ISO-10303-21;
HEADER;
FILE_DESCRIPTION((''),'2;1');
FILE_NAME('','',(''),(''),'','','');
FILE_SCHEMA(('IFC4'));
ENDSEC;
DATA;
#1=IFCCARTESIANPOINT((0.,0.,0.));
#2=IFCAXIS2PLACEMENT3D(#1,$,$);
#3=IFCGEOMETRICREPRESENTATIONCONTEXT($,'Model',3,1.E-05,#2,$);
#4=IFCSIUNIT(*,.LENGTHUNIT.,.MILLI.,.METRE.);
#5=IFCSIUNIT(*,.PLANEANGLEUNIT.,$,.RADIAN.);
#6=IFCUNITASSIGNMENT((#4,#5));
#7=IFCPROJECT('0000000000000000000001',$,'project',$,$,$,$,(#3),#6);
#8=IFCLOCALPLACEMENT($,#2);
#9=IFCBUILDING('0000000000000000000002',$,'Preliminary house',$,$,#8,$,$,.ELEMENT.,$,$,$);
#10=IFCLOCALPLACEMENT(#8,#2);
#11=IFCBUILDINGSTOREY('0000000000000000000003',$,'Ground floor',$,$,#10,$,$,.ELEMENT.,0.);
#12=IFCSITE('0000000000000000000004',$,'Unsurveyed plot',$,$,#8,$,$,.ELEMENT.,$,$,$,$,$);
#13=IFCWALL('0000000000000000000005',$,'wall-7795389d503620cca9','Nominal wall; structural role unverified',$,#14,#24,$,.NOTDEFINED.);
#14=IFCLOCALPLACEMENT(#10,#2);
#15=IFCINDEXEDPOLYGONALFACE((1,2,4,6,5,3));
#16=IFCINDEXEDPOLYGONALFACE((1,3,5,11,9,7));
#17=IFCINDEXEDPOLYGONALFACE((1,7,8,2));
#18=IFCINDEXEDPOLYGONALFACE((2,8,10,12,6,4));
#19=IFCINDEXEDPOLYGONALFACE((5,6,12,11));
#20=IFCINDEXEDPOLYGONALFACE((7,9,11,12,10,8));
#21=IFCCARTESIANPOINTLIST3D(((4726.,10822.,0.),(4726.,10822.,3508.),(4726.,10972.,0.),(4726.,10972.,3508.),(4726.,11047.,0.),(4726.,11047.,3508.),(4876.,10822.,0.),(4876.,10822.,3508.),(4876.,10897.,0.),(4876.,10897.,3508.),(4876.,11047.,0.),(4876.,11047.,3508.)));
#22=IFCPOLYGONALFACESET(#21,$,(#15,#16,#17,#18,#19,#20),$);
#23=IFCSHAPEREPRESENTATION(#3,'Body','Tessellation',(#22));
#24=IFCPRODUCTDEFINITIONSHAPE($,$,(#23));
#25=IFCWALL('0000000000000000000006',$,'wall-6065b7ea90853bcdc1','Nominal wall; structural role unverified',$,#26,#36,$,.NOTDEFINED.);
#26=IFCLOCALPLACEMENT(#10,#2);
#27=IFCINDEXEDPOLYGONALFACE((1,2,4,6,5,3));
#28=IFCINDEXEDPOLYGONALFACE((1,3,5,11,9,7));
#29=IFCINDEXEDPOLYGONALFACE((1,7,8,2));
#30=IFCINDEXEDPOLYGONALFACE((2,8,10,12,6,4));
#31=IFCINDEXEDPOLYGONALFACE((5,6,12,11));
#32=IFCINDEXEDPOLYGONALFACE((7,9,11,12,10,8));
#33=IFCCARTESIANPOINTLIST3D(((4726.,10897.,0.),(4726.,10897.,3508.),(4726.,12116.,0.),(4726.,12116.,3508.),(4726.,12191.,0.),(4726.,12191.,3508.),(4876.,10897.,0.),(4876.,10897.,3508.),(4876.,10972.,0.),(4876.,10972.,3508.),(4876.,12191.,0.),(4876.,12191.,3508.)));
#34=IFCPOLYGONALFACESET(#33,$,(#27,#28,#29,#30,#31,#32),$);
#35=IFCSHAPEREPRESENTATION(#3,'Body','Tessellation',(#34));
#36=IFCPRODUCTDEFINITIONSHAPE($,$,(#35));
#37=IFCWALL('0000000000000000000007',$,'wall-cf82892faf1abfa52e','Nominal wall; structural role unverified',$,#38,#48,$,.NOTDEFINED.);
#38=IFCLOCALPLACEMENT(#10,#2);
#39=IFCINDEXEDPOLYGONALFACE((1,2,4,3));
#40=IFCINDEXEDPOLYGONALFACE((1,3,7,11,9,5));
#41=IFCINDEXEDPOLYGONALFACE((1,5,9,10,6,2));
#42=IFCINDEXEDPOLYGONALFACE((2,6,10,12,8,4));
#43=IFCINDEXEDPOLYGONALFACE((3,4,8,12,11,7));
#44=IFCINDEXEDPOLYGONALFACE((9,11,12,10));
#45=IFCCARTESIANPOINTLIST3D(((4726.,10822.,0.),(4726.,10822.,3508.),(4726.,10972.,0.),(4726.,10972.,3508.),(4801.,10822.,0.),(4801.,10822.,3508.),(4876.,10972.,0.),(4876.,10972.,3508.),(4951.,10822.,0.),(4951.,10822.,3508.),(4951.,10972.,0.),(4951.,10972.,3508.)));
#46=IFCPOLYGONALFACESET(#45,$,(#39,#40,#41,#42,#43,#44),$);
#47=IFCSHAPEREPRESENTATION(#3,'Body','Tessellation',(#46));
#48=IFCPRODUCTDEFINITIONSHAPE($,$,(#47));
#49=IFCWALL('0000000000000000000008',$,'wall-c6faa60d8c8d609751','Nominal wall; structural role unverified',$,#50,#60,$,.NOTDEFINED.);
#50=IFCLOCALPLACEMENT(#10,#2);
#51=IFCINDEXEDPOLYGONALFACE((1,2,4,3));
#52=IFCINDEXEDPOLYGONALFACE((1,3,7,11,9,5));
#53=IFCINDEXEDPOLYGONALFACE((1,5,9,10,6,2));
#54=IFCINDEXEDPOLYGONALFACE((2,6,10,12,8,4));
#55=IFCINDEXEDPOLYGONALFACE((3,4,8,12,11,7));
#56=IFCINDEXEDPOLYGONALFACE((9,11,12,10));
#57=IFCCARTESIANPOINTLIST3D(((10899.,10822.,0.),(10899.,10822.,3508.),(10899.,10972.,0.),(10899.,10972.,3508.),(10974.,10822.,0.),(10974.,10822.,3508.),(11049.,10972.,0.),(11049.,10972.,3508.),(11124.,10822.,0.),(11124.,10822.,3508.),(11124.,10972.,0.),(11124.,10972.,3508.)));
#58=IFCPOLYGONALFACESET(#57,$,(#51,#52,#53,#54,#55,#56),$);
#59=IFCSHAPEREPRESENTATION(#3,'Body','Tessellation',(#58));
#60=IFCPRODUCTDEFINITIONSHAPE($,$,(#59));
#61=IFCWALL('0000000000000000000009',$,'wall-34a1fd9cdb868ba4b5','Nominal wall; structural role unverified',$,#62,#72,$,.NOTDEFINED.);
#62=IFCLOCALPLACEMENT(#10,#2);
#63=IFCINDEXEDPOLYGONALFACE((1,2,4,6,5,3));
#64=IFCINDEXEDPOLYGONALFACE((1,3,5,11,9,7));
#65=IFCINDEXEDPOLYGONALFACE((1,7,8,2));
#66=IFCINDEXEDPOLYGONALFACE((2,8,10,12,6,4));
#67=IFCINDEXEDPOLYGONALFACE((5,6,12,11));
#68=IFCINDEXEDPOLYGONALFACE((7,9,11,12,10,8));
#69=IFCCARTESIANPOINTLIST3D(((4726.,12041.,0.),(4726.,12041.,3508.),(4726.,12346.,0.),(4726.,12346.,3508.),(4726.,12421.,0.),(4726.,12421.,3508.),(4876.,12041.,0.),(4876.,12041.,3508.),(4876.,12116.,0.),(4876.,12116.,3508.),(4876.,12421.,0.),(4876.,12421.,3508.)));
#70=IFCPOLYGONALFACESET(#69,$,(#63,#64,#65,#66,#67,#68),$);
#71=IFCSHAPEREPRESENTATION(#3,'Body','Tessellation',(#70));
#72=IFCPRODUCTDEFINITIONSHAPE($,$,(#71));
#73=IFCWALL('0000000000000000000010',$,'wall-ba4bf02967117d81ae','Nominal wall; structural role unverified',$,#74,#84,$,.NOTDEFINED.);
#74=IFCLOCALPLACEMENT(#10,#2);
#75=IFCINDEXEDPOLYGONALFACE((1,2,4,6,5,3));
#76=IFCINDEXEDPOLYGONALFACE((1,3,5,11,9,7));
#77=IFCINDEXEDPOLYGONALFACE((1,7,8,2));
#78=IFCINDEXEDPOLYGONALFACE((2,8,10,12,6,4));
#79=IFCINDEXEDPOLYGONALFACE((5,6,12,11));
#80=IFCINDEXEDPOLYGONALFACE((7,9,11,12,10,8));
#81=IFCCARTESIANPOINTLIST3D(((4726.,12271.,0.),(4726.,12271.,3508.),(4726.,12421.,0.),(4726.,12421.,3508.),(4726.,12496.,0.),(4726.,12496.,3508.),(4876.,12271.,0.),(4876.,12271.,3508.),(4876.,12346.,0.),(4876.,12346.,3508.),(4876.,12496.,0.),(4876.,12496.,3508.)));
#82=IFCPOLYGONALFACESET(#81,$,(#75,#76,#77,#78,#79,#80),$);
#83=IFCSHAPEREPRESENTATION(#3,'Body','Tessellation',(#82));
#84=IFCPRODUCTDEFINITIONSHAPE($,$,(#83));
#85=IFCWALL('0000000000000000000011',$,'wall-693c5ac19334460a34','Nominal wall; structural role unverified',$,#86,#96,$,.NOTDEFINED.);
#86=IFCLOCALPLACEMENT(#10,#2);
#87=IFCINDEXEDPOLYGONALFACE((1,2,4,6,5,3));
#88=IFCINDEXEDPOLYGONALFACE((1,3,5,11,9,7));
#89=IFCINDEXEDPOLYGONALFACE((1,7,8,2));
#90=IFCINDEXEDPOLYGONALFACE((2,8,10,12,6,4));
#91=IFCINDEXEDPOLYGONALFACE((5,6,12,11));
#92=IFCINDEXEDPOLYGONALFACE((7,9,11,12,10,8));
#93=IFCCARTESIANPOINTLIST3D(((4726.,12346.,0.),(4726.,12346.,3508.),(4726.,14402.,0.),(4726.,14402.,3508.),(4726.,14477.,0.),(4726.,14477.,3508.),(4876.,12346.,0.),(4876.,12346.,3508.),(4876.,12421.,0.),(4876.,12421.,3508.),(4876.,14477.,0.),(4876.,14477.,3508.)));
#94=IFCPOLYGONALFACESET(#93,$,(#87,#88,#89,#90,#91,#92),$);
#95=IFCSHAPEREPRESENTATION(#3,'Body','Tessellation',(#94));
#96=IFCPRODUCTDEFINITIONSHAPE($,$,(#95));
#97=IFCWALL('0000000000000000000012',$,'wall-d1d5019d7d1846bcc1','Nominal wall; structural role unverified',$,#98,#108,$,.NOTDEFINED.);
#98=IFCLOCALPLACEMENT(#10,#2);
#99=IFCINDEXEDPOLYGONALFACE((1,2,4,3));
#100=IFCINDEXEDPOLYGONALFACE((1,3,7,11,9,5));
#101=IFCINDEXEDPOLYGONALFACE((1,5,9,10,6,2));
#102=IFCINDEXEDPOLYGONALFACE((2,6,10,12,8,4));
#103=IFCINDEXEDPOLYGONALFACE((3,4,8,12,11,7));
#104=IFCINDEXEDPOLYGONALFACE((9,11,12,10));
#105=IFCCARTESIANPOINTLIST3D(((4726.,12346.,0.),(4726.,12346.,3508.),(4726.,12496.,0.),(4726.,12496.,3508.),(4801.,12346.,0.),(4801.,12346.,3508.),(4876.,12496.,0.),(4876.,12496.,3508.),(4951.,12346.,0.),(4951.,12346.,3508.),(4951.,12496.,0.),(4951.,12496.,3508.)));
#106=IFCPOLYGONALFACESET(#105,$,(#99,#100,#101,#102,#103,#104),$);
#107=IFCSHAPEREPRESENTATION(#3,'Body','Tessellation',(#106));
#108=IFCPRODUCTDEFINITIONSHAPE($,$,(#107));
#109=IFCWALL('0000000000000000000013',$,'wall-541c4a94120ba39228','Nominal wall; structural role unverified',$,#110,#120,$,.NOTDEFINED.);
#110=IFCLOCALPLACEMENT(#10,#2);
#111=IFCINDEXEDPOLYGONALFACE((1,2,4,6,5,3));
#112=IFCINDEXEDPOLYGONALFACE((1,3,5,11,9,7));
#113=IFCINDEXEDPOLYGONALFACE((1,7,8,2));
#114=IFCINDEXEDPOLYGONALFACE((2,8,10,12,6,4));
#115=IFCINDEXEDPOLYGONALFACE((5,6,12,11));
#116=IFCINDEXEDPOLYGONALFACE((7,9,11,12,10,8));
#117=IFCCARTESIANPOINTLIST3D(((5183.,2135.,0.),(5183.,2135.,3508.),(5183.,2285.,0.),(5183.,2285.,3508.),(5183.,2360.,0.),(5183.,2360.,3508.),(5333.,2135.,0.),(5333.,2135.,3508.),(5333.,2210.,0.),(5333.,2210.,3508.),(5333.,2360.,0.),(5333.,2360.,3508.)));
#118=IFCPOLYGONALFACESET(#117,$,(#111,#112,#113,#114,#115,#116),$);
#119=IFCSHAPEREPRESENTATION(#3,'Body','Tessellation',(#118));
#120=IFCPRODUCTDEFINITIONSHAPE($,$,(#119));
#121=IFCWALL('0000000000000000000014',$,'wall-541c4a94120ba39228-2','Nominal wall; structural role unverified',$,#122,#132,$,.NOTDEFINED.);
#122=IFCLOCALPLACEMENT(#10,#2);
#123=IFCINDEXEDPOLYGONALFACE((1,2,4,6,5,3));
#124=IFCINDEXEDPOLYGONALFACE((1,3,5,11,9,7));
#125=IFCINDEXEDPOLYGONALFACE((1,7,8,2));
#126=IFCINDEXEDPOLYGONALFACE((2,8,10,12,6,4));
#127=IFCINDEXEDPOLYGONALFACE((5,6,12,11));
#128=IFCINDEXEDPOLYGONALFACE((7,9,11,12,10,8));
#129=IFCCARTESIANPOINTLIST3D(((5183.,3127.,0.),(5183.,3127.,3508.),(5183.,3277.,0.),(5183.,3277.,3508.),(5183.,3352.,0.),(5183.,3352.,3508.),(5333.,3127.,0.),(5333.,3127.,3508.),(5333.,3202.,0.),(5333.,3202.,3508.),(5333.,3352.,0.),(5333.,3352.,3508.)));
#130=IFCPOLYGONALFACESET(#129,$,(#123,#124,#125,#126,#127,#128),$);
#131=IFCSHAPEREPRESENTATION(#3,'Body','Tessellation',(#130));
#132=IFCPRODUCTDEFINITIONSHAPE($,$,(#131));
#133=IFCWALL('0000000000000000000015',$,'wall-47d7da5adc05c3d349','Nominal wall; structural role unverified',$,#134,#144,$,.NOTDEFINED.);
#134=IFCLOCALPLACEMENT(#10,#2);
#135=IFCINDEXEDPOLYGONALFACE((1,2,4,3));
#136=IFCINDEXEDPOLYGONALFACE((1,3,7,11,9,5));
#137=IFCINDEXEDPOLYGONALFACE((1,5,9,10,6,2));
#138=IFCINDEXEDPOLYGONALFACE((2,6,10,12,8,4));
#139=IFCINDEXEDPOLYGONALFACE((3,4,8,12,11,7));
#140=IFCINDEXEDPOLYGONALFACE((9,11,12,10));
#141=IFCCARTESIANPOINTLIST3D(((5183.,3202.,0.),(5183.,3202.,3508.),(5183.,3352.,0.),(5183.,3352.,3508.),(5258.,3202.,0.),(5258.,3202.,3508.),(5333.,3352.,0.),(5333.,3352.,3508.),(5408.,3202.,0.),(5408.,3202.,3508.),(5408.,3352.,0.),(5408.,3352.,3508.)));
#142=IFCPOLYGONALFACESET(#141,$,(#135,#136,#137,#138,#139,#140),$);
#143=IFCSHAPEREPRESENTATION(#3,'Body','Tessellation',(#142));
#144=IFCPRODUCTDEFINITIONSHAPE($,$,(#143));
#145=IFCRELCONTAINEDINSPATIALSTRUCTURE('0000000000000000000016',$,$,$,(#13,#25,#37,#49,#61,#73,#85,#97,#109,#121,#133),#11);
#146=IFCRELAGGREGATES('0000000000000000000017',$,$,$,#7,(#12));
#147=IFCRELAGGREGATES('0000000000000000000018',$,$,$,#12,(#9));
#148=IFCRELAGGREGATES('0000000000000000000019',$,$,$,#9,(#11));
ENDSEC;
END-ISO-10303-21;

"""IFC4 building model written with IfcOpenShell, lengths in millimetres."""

from ifc_helpers import new_model, si_unit, origin, place, context, project, spatial, polyline, outline, extrude, element, save


model = new_model("IFC4")

# Units and contexts
model_context = context("Model", 3, precision=1e-05, world=origin())
ifc_project = project(units=[si_unit("LENGTHUNIT", "METRE", prefix="MILLI"), si_unit("PLANEANGLEUNIT", "RADIAN")], contexts=[model_context])

# Site, building, storey
placement_1 = place(None, origin())
site = spatial("IfcSite", under=ifc_project, at=placement_1, Name="Unsurveyed plot", CompositionType="ELEMENT")
building = spatial("IfcBuilding", under=site, at=placement_1, Name="Preliminary house", CompositionType="ELEMENT")
placement_2 = place(placement_1, origin())
storey = spatial("IfcBuildingStorey", under=building, at=placement_2, Name="Ground floor", CompositionType="ELEMENT", Elevation=0.0)

# Walls
element("IfcWall", 1, at=placement_2, inside=storey, Name="wall-7795389d503620cca9", Description="Nominal wall; structural role unverified", PredefinedType="NOTDEFINED", context=model_context, shape_type="SweptSolid", body=[
    extrude(outline(polyline([(4726.0, 10972.0), (4726.0, 11047.0), (4876.0, 11047.0), (4876.0, 10897.0), (4876.0, 10822.0), (4726.0, 10822.0), (4726.0, 10972.0)])), origin(), (0.0, 0.0, 1.0), 3508.0),
])
element("IfcWall", 2, at=placement_2, inside=storey, Name="wall-6065b7ea90853bcdc1", Description="Nominal wall; structural role unverified", PredefinedType="NOTDEFINED", context=model_context, shape_type="SweptSolid", body=[
    extrude(outline(polyline([(4726.0, 12116.0), (4726.0, 12191.0), (4876.0, 12191.0), (4876.0, 10972.0), (4876.0, 10897.0), (4726.0, 10897.0), (4726.0, 12116.0)])), origin(), (0.0, 0.0, 1.0), 3508.0),
])
element("IfcWall", 3, at=placement_2, inside=storey, Name="wall-cf82892faf1abfa52e", Description="Nominal wall; structural role unverified", PredefinedType="NOTDEFINED", context=model_context, shape_type="SweptSolid", body=[
    extrude(outline(polyline([(4876.0, 10972.0), (4951.0, 10972.0), (4951.0, 10822.0), (4801.0, 10822.0), (4726.0, 10822.0), (4726.0, 10972.0), (4876.0, 10972.0)])), origin(), (0.0, 0.0, 1.0), 3508.0),
])

# Walls
element("IfcWall", 4, at=placement_2, inside=storey, Name="wall-c6faa60d8c8d609751", Description="Nominal wall; structural role unverified", PredefinedType="NOTDEFINED", context=model_context, shape_type="SweptSolid", body=[
    extrude(outline(polyline([(11049.0, 10972.0), (11124.0, 10972.0), (11124.0, 10822.0), (10974.0, 10822.0), (10899.0, 10822.0), (10899.0, 10972.0), (11049.0, 10972.0)])), origin(), (0.0, 0.0, 1.0), 3508.0),
])
element("IfcWall", 5, at=placement_2, inside=storey, Name="wall-34a1fd9cdb868ba4b5", Description="Nominal wall; structural role unverified", PredefinedType="NOTDEFINED", context=model_context, shape_type="SweptSolid", body=[
    extrude(outline(polyline([(4726.0, 12346.0), (4726.0, 12421.0), (4876.0, 12421.0), (4876.0, 12116.0), (4876.0, 12041.0), (4726.0, 12041.0), (4726.0, 12346.0)])), origin(), (0.0, 0.0, 1.0), 3508.0),
])
element("IfcWall", 6, at=placement_2, inside=storey, Name="wall-ba4bf02967117d81ae", Description="Nominal wall; structural role unverified", PredefinedType="NOTDEFINED", context=model_context, shape_type="SweptSolid", body=[
    extrude(outline(polyline([(4726.0, 12421.0), (4726.0, 12496.0), (4876.0, 12496.0), (4876.0, 12346.0), (4876.0, 12271.0), (4726.0, 12271.0), (4726.0, 12421.0)])), origin(), (0.0, 0.0, 1.0), 3508.0),
])
element("IfcWall", 7, at=placement_2, inside=storey, Name="wall-693c5ac19334460a34", Description="Nominal wall; structural role unverified", PredefinedType="NOTDEFINED", context=model_context, shape_type="SweptSolid", body=[
    extrude(outline(polyline([(4726.0, 14402.0), (4726.0, 14477.0), (4876.0, 14477.0), (4876.0, 12421.0), (4876.0, 12346.0), (4726.0, 12346.0), (4726.0, 14402.0)])), origin(), (0.0, 0.0, 1.0), 3508.0),
])
element("IfcWall", 8, at=placement_2, inside=storey, Name="wall-d1d5019d7d1846bcc1", Description="Nominal wall; structural role unverified", PredefinedType="NOTDEFINED", context=model_context, shape_type="SweptSolid", body=[
    extrude(outline(polyline([(4876.0, 12496.0), (4951.0, 12496.0), (4951.0, 12346.0), (4801.0, 12346.0), (4726.0, 12346.0), (4726.0, 12496.0), (4876.0, 12496.0)])), origin(), (0.0, 0.0, 1.0), 3508.0),
])

# Wall
element("IfcWall", 9, at=placement_2, inside=storey, Name="wall-541c4a94120ba39228", Description="Nominal wall; structural role unverified", PredefinedType="NOTDEFINED", context=model_context, shape_type="SweptSolid", body=[
    extrude(outline(polyline([(5183.0, 2285.0), (5183.0, 2360.0), (5333.0, 2360.0), (5333.0, 2210.0), (5333.0, 2135.0), (5183.0, 2135.0), (5183.0, 2285.0)])), origin(), (0.0, 0.0, 1.0), 3508.0),
])

# Wall
element("IfcWall", 10, at=placement_2, inside=storey, Name="wall-541c4a94120ba39228-2", Description="Nominal wall; structural role unverified", PredefinedType="NOTDEFINED", context=model_context, shape_type="SweptSolid", body=[
    extrude(outline(polyline([(5183.0, 3277.0), (5183.0, 3352.0), (5333.0, 3352.0), (5333.0, 3202.0), (5333.0, 3127.0), (5183.0, 3127.0), (5183.0, 3277.0)])), origin(), (0.0, 0.0, 1.0), 3508.0),
])

# Wall
element("IfcWall", 11, at=placement_2, inside=storey, Name="wall-47d7da5adc05c3d349", Description="Nominal wall; structural role unverified", PredefinedType="NOTDEFINED", context=model_context, shape_type="SweptSolid", body=[
    extrude(outline(polyline([(5333.0, 3352.0), (5408.0, 3352.0), (5408.0, 3202.0), (5258.0, 3202.0), (5183.0, 3202.0), (5183.0, 3352.0), (5333.0, 3352.0)])), origin(), (0.0, 0.0, 1.0), 3508.0),
])

save(model, "model.ifc")
